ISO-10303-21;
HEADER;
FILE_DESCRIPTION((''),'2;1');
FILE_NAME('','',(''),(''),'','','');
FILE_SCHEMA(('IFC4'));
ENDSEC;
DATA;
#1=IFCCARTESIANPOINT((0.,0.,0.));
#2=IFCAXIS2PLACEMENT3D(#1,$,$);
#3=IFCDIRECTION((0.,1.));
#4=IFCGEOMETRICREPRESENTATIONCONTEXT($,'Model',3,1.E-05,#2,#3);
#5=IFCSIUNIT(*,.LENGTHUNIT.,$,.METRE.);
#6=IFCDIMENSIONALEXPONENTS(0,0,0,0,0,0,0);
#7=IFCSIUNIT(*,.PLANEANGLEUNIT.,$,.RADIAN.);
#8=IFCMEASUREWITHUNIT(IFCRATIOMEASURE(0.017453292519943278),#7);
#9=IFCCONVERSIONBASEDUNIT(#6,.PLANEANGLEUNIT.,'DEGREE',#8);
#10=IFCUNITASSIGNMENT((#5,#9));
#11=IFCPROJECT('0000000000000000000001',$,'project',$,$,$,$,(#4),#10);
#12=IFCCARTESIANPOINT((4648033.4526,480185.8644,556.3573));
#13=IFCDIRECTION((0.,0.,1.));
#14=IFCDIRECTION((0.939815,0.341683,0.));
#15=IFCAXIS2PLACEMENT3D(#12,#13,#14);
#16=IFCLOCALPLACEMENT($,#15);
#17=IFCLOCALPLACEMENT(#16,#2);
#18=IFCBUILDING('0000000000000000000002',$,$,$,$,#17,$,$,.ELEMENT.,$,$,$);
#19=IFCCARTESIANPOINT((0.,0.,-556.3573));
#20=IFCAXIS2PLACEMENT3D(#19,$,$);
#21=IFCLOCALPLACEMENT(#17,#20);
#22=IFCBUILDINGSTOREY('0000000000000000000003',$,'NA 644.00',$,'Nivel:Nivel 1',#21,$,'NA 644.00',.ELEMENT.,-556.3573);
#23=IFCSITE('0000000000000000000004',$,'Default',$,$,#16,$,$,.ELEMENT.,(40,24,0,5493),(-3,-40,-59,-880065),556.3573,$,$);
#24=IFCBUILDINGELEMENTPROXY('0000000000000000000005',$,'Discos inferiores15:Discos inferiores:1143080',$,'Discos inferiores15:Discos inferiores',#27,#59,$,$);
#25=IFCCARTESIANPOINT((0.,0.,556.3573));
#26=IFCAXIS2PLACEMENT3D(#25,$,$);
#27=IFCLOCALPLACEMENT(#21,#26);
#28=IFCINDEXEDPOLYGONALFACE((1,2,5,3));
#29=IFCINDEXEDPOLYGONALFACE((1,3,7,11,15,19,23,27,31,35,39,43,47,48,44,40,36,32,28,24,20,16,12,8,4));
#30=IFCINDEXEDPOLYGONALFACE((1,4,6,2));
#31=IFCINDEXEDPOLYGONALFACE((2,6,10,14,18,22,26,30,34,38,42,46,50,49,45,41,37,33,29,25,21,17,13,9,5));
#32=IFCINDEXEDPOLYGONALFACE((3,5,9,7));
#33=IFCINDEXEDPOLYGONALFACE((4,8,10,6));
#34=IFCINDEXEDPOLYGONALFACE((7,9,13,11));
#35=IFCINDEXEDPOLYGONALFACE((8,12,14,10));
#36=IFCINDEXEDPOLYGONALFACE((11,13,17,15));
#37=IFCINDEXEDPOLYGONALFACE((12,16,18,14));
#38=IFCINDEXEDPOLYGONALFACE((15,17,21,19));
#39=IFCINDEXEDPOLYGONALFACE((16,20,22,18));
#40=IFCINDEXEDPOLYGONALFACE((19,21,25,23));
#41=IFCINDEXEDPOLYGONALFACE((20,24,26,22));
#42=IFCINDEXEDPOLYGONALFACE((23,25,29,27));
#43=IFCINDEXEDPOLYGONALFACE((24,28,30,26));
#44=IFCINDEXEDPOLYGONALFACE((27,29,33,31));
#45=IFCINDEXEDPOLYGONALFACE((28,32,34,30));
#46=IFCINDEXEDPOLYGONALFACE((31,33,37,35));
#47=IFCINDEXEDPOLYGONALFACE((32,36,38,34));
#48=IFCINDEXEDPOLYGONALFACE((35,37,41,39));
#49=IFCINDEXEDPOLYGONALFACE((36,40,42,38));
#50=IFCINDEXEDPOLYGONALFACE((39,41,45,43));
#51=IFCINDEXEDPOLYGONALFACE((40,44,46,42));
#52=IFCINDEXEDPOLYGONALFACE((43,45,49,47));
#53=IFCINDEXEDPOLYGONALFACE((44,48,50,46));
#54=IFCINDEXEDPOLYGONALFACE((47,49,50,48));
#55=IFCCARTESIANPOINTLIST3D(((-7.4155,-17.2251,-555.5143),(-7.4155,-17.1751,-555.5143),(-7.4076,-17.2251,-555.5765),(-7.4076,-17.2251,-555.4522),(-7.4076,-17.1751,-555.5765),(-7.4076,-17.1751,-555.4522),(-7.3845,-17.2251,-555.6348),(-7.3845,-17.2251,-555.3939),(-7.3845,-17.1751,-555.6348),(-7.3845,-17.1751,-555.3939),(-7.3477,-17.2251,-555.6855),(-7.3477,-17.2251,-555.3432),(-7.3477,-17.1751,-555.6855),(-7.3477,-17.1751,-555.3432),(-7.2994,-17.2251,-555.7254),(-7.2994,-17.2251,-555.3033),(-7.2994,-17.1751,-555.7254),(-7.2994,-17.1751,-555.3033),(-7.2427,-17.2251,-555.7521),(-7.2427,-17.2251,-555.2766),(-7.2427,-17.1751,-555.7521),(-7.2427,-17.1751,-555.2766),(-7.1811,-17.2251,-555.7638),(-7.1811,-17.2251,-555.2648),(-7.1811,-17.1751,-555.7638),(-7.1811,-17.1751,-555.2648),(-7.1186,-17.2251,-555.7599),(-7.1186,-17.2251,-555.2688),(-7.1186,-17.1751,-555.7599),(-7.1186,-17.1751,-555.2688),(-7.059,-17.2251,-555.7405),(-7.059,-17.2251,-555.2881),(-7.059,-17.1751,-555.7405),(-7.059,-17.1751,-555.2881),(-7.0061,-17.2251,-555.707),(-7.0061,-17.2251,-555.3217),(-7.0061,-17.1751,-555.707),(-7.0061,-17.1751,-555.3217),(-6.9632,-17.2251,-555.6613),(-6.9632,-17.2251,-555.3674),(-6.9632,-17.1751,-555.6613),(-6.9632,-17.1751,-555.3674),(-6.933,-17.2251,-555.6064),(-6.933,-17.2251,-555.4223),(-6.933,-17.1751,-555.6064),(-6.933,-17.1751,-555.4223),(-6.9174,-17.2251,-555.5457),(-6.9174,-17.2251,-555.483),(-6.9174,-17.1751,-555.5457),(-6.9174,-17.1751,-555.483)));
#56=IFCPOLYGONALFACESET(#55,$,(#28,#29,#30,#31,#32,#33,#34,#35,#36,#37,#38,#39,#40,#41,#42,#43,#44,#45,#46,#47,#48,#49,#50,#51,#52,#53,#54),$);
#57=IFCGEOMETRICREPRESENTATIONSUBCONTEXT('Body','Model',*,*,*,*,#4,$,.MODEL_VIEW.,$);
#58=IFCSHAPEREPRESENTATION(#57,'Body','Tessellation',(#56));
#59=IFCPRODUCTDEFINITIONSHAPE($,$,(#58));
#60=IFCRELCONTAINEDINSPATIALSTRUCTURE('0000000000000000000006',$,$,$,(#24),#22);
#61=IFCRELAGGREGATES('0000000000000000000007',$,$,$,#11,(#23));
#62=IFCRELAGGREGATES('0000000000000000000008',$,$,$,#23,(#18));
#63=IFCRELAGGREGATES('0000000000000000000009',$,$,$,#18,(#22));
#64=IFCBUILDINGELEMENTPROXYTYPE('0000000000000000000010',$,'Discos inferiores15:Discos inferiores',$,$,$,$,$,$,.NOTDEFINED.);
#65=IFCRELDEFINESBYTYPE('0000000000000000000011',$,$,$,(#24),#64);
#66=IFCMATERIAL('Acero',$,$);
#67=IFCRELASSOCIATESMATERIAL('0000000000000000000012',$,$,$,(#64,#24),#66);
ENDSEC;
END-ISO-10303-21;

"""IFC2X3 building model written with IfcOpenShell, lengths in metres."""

from ifc_helpers import new_model, entity, si_unit, converted_unit, direction, frame, origin, origin_2d_with_axis, place, context, subcontext, project, spatial, circle, extrude, source, transform, mapped, material, type_object, type_shapes, element, save


model = new_model("IFC2X3")

# Units and contexts
model_context = context("Model", 3, precision=1e-05, world=origin(), true_north=direction((0.0, 1.0)))
body_context = subcontext(model_context, "Body", "Model", "MODEL_VIEW")
ifc_project = project(units=[si_unit("LENGTHUNIT", "METRE"), converted_unit("PLANEANGLEUNIT", "DEGREE", entity("IfcRatioMeasure", 0.017453292519943278), si_unit("PLANEANGLEUNIT", "RADIAN"), dimensions=[0, 0, 0, 0, 0, 0, 0])], contexts=[model_context])

# Site, building, storey
site_placement = place(None, frame((4648033.4526, 480185.8644, 556.3573), z_axis=(0.0, 0.0, 1.0), x_axis=(0.939815, 0.341683, 0.0)))
site = spatial("IfcSite", under=ifc_project, at=site_placement, Name="Default", CompositionType="ELEMENT", RefLatitude=(40, 24, 0, 5493), RefLongitude=(-3, -40, -59, -880065), RefElevation=556.3573)
building_placement = place(site_placement, origin())
building = spatial("IfcBuilding", under=site, at=building_placement, CompositionType="ELEMENT")
storey_placement = place(building_placement, frame((0.0, 0.0, -556.3573)))
storey = spatial("IfcBuildingStorey", under=building, at=storey_placement, Name="NA 644.00", ObjectType="Nivel:Nivel 1", LongName="NA 644.00", CompositionType="ELEMENT", Elevation=-556.3573)

# Building element proxy
ifc_material_1 = material(Name="Acero")
building_element_proxy_type_1 = type_object("IfcBuildingElementProxyType", Name="Discos inferiores15:Discos inferiores", PredefinedType="NOTDEFINED", material=ifc_material_1)
shared_shape_1 = source(origin(), body_context, "Body", "SweptSolid", [
    extrude(circle(Radius=0.25, at=origin_2d_with_axis()), frame((-7.1655, -17.2251, -555.5143), z_axis=(0.0, 1.0, 0.0), x_axis=(-1.0, 0.0, 0.0)), (0.0, 0.0, 1.0), 0.05),
])
type_shapes(building_element_proxy_type_1, [shared_shape_1])
proxy_1_placement = place(storey_placement, frame((0.0, 0.0, 556.3573)))
element("IfcBuildingElementProxy", 1, at=proxy_1_placement, inside=storey, type_object=building_element_proxy_type_1, material=ifc_material_1, Name="Discos inferiores15:Discos inferiores:1143080", ObjectType="Discos inferiores15:Discos inferiores", context=body_context, shape_type="MappedRepresentation", body=[
    mapped(shared_shape_1, transform((0.0, 0.0, 0.0), scale=1.0)),
])

save(model, "model.ifc")
